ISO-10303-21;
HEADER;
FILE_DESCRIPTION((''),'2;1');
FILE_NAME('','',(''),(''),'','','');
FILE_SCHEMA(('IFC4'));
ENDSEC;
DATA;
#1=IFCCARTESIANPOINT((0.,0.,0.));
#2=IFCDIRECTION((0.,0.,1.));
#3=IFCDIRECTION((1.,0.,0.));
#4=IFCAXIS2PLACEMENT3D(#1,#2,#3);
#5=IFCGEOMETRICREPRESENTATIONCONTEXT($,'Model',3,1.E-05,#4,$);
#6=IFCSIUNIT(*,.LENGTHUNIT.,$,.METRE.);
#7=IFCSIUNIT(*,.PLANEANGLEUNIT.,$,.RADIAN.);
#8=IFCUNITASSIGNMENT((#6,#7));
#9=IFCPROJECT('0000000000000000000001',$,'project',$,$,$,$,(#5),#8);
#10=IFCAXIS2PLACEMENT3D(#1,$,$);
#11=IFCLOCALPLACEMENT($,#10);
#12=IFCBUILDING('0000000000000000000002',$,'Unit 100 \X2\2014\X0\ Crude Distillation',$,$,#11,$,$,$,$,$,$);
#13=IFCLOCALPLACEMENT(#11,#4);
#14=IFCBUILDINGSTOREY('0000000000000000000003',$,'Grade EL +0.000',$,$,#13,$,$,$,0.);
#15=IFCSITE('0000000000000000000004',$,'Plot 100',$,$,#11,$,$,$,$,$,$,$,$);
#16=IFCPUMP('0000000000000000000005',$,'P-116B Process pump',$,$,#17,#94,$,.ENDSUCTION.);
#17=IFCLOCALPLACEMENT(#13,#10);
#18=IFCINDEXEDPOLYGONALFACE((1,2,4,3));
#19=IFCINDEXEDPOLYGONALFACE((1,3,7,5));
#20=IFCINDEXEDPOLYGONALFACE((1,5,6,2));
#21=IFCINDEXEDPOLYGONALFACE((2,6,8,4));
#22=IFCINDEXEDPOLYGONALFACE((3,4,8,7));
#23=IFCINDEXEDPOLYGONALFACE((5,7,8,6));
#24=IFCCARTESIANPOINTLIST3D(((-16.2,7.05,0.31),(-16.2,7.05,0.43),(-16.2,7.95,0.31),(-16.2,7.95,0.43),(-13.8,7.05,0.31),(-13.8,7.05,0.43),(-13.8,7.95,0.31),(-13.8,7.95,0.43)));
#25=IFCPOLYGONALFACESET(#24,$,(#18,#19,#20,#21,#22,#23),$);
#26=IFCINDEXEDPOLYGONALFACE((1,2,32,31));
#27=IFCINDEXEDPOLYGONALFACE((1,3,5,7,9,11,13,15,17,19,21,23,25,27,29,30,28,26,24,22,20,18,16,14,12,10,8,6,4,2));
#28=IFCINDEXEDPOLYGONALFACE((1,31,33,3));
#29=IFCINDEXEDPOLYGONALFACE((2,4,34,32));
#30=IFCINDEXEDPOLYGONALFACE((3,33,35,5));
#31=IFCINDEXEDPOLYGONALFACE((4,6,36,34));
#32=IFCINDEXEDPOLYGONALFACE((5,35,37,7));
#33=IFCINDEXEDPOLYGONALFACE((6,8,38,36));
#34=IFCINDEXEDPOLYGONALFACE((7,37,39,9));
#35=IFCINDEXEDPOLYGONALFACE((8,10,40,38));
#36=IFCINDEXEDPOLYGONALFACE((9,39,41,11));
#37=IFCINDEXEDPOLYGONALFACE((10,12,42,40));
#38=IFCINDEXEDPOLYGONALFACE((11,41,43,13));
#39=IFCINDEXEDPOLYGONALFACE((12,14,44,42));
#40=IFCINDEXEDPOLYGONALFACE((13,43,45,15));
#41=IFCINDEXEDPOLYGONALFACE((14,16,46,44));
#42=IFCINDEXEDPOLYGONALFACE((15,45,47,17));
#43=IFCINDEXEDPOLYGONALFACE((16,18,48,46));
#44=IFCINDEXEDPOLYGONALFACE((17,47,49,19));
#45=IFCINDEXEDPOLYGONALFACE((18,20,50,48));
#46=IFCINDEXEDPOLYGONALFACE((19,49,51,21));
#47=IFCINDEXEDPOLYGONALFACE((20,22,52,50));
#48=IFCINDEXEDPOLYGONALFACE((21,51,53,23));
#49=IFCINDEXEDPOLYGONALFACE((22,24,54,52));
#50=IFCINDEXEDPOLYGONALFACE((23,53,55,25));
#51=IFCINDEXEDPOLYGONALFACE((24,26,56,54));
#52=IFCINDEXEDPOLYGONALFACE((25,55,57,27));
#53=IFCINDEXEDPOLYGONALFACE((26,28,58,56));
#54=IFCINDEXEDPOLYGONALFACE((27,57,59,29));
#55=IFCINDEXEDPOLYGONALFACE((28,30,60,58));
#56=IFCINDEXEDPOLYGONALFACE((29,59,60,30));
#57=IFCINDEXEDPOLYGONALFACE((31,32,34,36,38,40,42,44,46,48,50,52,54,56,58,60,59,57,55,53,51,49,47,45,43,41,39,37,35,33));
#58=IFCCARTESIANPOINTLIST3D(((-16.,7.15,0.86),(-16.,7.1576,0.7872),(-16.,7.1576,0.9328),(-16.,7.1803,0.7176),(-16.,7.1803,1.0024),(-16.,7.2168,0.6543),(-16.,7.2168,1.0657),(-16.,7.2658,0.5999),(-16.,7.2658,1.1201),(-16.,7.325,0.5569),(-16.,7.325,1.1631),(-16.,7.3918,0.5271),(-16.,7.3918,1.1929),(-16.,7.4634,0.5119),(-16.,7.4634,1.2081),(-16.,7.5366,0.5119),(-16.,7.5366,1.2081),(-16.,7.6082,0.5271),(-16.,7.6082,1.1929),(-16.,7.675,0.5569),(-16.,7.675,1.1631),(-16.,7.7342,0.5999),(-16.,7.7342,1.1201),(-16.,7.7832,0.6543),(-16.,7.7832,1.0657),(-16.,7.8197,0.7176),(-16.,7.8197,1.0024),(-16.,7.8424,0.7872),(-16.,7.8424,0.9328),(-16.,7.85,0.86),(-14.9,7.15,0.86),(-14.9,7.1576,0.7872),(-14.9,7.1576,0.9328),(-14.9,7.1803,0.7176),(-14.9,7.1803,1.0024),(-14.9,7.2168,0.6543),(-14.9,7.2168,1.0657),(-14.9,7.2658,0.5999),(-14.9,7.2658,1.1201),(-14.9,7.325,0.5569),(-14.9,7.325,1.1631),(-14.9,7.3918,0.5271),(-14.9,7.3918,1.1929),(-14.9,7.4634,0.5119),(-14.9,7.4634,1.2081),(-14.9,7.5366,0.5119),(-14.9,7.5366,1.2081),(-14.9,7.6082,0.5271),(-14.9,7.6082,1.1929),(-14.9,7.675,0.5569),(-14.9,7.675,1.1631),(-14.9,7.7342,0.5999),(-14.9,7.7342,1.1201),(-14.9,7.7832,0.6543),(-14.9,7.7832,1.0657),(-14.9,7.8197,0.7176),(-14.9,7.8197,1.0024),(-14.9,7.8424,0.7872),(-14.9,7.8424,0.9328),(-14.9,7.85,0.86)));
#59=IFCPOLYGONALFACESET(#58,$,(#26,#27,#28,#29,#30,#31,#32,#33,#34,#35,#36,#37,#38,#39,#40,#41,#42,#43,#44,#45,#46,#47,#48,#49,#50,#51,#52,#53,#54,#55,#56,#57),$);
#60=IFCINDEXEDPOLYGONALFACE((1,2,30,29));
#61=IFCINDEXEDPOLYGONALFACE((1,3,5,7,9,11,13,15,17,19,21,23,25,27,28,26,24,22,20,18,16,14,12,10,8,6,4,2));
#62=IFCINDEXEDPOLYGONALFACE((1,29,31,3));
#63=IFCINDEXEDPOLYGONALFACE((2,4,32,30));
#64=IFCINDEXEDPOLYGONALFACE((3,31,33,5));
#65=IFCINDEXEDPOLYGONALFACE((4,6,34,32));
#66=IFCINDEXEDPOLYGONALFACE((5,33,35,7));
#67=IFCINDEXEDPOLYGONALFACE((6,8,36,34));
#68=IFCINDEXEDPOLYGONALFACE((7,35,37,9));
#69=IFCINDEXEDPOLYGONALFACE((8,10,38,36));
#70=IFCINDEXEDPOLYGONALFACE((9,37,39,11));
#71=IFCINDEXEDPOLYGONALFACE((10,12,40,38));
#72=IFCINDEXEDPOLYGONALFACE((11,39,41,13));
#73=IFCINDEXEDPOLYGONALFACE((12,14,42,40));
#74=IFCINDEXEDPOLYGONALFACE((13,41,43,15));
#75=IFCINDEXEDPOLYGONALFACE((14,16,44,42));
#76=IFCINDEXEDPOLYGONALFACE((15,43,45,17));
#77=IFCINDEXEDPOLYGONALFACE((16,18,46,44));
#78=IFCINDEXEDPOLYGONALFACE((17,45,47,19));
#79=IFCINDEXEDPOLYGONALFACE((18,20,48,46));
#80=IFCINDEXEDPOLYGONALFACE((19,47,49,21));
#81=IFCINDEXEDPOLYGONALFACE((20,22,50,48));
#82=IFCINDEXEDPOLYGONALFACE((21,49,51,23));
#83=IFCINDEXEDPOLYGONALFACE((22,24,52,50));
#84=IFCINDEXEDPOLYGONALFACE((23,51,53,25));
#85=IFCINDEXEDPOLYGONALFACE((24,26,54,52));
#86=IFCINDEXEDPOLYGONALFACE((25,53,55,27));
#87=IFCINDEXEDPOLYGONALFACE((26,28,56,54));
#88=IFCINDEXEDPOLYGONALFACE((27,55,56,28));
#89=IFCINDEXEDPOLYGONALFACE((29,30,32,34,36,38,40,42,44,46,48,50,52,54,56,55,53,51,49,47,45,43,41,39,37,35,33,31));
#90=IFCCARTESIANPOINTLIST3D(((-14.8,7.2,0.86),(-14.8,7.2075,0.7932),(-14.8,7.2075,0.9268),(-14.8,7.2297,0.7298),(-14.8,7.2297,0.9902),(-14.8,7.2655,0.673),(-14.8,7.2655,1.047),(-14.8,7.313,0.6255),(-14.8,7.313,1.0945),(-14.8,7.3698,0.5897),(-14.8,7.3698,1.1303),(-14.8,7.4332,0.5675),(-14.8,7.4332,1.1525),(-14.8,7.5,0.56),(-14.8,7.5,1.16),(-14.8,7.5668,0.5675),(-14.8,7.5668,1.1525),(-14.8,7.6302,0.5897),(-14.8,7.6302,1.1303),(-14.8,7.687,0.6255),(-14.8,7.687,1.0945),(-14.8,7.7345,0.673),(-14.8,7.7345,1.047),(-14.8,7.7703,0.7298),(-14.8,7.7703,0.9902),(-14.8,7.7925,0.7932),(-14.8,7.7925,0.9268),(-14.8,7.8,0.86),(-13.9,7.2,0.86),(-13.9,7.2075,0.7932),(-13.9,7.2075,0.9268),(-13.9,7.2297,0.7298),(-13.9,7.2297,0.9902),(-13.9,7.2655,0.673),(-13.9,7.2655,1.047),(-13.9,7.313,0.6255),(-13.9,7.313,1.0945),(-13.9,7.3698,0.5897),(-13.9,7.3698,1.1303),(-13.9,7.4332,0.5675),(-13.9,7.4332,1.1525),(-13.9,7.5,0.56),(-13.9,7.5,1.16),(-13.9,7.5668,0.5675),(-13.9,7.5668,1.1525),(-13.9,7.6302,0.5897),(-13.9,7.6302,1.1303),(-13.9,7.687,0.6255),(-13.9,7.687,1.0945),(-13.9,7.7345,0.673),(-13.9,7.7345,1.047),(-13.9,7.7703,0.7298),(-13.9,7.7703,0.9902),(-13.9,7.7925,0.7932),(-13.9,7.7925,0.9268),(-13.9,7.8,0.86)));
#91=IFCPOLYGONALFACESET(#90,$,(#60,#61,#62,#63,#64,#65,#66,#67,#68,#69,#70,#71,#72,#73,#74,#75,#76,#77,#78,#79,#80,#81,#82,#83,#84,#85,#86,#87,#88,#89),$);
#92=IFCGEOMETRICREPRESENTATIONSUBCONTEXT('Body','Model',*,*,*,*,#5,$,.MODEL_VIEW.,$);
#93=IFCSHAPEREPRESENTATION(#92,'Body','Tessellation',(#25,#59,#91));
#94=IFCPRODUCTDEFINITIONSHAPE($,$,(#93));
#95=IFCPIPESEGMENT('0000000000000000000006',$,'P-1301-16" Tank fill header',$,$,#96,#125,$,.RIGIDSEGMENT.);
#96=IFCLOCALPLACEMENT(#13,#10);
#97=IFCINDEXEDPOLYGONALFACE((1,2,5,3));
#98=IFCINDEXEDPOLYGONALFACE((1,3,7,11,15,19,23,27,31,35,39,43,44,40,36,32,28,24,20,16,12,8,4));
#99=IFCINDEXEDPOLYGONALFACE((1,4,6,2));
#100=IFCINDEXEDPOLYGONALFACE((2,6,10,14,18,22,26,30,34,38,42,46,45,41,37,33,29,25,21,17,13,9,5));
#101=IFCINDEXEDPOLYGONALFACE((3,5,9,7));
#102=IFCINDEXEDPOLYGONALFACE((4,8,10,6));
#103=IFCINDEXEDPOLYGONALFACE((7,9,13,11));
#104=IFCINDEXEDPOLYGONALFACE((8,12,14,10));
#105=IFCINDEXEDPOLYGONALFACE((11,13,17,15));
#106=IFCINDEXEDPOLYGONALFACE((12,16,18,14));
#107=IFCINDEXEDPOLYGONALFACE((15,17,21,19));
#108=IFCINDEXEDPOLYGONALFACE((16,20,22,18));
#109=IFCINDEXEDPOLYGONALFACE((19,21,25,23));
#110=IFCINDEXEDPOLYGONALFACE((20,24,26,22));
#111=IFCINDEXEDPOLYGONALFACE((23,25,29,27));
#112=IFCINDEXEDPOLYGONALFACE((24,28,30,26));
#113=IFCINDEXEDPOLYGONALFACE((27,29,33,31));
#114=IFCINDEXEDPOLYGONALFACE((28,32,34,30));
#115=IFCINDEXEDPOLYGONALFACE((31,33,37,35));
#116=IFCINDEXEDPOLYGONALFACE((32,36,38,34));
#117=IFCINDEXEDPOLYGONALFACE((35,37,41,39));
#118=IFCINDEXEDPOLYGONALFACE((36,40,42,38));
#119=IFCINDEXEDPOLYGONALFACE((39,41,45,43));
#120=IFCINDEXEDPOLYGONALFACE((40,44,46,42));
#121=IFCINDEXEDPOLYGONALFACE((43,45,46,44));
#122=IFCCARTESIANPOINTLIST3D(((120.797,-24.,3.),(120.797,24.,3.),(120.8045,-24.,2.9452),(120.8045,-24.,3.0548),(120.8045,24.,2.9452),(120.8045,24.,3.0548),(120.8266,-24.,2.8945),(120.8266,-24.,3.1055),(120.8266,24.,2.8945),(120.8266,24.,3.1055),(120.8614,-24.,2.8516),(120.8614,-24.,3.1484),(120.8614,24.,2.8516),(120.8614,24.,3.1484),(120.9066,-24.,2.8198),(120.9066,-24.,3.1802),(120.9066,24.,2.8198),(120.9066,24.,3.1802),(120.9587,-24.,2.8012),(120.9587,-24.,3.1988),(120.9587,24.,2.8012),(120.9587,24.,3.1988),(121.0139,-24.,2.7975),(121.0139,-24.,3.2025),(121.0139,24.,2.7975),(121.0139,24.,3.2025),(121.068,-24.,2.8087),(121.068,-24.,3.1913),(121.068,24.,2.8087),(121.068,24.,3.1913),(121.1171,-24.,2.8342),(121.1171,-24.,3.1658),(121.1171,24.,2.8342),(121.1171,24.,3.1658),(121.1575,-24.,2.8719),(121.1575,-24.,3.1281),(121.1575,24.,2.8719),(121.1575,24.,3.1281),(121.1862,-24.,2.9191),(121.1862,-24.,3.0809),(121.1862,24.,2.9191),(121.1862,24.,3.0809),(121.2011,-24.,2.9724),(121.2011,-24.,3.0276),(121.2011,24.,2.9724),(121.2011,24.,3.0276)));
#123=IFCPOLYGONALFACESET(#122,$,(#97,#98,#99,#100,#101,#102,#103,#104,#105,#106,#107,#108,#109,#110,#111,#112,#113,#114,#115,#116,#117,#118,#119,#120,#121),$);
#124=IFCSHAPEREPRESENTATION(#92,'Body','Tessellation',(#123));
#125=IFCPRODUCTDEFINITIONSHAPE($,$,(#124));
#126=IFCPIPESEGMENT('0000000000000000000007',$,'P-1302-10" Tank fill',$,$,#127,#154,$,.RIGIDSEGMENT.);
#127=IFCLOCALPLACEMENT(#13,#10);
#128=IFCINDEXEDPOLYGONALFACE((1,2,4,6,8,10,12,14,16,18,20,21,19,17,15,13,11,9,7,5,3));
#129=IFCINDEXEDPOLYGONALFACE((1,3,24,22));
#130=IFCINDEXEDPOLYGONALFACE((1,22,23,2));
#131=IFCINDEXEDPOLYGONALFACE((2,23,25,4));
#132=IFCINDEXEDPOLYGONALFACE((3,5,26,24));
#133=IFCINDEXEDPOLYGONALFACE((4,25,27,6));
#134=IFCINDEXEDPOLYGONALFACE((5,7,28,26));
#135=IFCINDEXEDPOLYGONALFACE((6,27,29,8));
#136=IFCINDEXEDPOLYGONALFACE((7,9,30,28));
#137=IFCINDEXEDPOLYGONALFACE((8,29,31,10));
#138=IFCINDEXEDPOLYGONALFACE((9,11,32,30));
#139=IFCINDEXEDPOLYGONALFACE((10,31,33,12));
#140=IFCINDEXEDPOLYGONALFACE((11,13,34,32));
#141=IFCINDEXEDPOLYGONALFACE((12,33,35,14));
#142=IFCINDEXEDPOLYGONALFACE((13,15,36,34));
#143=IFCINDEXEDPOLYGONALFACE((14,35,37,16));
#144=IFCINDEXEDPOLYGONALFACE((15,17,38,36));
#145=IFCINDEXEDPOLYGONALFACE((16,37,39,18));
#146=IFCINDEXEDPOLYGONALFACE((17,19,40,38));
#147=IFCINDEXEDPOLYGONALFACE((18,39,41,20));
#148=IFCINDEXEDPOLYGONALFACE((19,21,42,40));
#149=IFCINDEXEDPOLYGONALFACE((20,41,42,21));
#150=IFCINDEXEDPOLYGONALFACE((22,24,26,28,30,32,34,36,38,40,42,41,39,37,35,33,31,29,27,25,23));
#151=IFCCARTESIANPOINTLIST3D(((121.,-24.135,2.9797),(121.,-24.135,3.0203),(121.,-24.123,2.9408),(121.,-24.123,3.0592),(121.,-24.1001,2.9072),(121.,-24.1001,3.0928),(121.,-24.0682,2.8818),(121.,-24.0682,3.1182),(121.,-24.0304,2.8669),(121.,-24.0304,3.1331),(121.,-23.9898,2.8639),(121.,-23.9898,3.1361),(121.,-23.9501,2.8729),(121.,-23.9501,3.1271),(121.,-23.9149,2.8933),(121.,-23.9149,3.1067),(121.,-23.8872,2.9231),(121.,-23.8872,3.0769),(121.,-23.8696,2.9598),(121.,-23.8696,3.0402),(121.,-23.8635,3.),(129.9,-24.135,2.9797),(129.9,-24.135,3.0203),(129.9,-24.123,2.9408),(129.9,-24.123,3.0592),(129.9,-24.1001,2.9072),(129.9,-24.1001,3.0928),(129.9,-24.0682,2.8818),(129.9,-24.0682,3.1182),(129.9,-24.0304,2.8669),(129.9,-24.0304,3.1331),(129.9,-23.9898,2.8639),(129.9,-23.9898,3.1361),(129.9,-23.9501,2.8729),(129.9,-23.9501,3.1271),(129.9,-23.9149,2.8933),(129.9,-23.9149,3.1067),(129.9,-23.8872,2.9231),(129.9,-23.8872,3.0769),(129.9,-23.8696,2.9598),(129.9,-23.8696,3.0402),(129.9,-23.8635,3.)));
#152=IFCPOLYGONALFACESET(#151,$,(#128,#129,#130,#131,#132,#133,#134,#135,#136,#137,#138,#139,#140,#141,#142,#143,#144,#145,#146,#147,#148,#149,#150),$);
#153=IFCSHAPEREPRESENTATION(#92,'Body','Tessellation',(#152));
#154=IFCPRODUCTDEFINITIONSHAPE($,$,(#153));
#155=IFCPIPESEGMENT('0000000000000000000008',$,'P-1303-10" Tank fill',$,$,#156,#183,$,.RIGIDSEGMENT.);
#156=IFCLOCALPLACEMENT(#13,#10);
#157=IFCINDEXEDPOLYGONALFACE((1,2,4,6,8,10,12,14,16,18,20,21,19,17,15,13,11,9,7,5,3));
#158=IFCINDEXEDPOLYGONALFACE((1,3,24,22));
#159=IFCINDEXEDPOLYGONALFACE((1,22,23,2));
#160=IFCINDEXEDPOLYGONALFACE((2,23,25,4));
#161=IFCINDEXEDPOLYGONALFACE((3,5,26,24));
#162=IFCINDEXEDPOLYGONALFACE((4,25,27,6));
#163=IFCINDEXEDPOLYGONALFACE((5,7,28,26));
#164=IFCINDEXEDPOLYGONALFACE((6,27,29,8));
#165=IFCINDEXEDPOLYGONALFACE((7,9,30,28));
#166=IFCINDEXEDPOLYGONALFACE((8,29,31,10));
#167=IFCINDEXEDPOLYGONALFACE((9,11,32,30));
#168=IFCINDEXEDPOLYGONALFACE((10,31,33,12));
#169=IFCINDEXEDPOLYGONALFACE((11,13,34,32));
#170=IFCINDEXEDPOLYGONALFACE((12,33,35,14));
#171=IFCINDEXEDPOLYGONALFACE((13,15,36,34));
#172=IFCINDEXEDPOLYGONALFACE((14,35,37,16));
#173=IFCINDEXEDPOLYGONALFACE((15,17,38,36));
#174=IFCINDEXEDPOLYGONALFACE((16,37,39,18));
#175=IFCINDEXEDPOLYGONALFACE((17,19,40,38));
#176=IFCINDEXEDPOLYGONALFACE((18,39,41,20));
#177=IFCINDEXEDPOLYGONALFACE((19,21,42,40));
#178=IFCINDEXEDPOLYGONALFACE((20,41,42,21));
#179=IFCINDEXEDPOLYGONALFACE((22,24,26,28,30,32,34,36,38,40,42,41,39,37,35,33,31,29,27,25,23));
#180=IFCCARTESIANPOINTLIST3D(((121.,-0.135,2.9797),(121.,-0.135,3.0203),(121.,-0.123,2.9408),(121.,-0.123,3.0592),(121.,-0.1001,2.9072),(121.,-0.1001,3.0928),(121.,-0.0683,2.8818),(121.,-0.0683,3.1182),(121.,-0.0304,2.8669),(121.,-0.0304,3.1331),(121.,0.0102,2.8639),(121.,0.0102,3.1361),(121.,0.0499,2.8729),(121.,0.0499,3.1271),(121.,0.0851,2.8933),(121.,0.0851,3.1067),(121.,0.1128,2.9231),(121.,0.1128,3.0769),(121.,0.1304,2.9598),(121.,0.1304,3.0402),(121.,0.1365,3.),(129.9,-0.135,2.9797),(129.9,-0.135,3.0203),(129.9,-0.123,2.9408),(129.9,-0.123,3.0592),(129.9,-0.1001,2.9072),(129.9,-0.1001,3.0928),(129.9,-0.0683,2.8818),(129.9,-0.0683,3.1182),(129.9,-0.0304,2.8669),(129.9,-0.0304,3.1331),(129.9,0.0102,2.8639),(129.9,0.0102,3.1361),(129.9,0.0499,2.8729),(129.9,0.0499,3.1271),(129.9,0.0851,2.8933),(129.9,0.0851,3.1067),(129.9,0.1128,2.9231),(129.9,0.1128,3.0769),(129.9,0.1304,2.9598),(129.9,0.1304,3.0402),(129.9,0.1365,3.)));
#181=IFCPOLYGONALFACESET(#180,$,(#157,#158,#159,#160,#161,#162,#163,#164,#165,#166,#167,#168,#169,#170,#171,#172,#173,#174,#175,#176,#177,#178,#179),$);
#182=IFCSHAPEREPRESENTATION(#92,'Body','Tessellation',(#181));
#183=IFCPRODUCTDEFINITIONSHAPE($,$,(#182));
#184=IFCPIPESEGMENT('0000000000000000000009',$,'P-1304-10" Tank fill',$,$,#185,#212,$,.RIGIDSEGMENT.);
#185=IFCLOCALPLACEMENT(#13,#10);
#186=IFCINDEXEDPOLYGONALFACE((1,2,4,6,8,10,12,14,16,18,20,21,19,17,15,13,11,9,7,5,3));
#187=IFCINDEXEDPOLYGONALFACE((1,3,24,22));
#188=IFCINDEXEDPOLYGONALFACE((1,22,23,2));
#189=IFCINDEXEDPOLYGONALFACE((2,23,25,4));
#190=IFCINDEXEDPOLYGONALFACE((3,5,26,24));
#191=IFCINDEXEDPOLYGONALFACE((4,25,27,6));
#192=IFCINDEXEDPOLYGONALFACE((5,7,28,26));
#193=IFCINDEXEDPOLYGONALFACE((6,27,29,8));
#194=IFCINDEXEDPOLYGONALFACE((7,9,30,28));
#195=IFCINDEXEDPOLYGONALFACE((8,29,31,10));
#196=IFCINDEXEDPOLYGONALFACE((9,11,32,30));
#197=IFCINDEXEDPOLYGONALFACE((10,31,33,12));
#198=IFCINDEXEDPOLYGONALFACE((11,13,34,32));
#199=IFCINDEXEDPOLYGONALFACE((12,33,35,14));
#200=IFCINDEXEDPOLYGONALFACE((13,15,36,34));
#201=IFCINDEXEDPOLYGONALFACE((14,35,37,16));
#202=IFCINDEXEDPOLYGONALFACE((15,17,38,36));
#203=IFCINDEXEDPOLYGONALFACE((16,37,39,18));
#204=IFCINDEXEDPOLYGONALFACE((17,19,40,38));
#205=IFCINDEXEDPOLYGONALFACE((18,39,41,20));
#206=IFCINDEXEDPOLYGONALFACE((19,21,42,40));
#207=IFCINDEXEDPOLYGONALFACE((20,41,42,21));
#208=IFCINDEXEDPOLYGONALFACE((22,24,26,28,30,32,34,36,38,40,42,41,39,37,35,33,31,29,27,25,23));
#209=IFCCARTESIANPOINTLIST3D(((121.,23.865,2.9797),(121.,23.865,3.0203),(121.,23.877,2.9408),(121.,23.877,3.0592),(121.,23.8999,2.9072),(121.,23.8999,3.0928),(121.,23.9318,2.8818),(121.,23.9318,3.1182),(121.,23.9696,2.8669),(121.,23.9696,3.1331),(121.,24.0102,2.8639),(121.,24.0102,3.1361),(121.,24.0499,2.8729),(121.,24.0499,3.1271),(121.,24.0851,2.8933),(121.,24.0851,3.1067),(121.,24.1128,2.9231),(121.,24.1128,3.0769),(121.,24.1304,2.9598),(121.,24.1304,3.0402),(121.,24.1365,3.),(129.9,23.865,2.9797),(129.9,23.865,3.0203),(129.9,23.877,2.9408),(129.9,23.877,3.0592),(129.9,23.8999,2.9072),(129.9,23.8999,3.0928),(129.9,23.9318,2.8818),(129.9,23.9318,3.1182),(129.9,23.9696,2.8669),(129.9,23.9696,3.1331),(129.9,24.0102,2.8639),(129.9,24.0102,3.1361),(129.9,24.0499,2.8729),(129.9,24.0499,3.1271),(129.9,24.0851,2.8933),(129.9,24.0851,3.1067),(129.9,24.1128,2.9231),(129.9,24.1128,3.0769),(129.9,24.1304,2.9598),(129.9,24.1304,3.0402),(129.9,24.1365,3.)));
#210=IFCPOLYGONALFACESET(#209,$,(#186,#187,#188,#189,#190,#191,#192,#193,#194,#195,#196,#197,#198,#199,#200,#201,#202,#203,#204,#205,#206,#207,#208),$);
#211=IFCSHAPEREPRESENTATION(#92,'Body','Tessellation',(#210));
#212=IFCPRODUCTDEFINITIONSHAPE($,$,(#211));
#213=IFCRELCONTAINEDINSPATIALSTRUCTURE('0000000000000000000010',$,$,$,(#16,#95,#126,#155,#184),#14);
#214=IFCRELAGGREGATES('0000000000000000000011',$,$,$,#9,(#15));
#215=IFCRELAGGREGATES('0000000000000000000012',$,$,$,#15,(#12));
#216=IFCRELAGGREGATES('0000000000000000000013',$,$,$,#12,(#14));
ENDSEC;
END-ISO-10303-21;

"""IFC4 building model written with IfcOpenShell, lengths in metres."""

from ifc_helpers import new_model, si_unit, frame, origin, origin_with_axes, origin_2d, place, context, subcontext, project, spatial, rectangle, circle, extrude, element, save


model = new_model("IFC4")

# Units and contexts
model_context = context("Model", 3, precision=1e-05, world=origin_with_axes())
body_context = subcontext(model_context, "Body", "Model", "MODEL_VIEW")
ifc_project = project(units=[si_unit("LENGTHUNIT", "METRE"), si_unit("PLANEANGLEUNIT", "RADIAN")], contexts=[model_context])

# Site, building, storey
placement = place(None, origin())
site = spatial("IfcSite", under=ifc_project, at=placement, Name="Plot 100")
building = spatial("IfcBuilding", under=site, at=placement, Name="Unit 100 — Crude Distillation")
storey_placement = place(placement, origin_with_axes())
storey = spatial("IfcBuildingStorey", under=building, at=storey_placement, Name="Grade EL +0.000", Elevation=0.0)

# Pump
pump_1_placement = place(storey_placement, origin_with_axes())
element("IfcPump", 1, at=pump_1_placement, inside=storey, Name="P-116B Process pump", PredefinedType="ENDSUCTION", context=body_context, shape_type="SweptSolid", body=[
    extrude(rectangle(XDim=2.4, YDim=0.9, at=origin_2d()), frame((-15.0, 7.5, 0.31), z_axis=(0.0, 0.0, 1.0), x_axis=(1.0, 0.0, 0.0)), (0.0, 0.0, 1.0), 0.12),
    extrude(circle(Radius=0.35, at=origin_2d()), frame((-16.0, 7.5, 0.86), z_axis=(1.0, 0.0, 0.0), x_axis=(0.0, 1.0, 0.0)), (0.0, 0.0, 1.0), 1.1),
    extrude(circle(Radius=0.3, at=origin_2d()), frame((-14.8, 7.5, 0.86), z_axis=(1.0, 0.0, 0.0), x_axis=(0.0, 1.0, 0.0)), (0.0, 0.0, 1.0), 0.9),
])

# Pipe segments
pipe_segment_1_placement = place(storey_placement, origin_with_axes())
element("IfcPipeSegment", 2, at=pipe_segment_1_placement, inside=storey, Name="P-1301-16\" Tank fill header", PredefinedType="RIGIDSEGMENT", context=body_context, shape_type="SweptSolid", body=[
    extrude(circle(Radius=0.203, at=origin_2d()), frame((121.0, -24.0, 3.0), z_axis=(0.0, 1.0, 0.0), x_axis=(-1.0, 0.0, 0.0)), (0.0, 0.0, 1.0), 48.0),
])
pipe_segment_2_placement = place(storey_placement, origin_with_axes())
element("IfcPipeSegment", 3, at=pipe_segment_2_placement, inside=storey, Name="P-1302-10\" Tank fill", PredefinedType="RIGIDSEGMENT", context=body_context, shape_type="SweptSolid", body=[
    extrude(circle(Radius=0.1365, at=origin_2d()), frame((121.0, -24.0, 3.0), z_axis=(1.0, 0.0, 0.0), x_axis=(0.0, 1.0, 0.0)), (0.0, 0.0, 1.0), 8.9),
])
pipe_segment_3_placement = place(storey_placement, origin_with_axes())
element("IfcPipeSegment", 4, at=pipe_segment_3_placement, inside=storey, Name="P-1303-10\" Tank fill", PredefinedType="RIGIDSEGMENT", context=body_context, shape_type="SweptSolid", body=[
    extrude(circle(Radius=0.1365, at=origin_2d()), frame((121.0, 0.0, 3.0), z_axis=(1.0, 0.0, 0.0), x_axis=(0.0, 1.0, 0.0)), (0.0, 0.0, 1.0), 8.9),
])
pipe_segment_4_placement = place(storey_placement, origin_with_axes())
element("IfcPipeSegment", 5, at=pipe_segment_4_placement, inside=storey, Name="P-1304-10\" Tank fill", PredefinedType="RIGIDSEGMENT", context=body_context, shape_type="SweptSolid", body=[
    extrude(circle(Radius=0.1365, at=origin_2d()), frame((121.0, 24.0, 3.0), z_axis=(1.0, 0.0, 0.0), x_axis=(0.0, 1.0, 0.0)), (0.0, 0.0, 1.0), 8.9),
])

save(model, "model.ifc")
